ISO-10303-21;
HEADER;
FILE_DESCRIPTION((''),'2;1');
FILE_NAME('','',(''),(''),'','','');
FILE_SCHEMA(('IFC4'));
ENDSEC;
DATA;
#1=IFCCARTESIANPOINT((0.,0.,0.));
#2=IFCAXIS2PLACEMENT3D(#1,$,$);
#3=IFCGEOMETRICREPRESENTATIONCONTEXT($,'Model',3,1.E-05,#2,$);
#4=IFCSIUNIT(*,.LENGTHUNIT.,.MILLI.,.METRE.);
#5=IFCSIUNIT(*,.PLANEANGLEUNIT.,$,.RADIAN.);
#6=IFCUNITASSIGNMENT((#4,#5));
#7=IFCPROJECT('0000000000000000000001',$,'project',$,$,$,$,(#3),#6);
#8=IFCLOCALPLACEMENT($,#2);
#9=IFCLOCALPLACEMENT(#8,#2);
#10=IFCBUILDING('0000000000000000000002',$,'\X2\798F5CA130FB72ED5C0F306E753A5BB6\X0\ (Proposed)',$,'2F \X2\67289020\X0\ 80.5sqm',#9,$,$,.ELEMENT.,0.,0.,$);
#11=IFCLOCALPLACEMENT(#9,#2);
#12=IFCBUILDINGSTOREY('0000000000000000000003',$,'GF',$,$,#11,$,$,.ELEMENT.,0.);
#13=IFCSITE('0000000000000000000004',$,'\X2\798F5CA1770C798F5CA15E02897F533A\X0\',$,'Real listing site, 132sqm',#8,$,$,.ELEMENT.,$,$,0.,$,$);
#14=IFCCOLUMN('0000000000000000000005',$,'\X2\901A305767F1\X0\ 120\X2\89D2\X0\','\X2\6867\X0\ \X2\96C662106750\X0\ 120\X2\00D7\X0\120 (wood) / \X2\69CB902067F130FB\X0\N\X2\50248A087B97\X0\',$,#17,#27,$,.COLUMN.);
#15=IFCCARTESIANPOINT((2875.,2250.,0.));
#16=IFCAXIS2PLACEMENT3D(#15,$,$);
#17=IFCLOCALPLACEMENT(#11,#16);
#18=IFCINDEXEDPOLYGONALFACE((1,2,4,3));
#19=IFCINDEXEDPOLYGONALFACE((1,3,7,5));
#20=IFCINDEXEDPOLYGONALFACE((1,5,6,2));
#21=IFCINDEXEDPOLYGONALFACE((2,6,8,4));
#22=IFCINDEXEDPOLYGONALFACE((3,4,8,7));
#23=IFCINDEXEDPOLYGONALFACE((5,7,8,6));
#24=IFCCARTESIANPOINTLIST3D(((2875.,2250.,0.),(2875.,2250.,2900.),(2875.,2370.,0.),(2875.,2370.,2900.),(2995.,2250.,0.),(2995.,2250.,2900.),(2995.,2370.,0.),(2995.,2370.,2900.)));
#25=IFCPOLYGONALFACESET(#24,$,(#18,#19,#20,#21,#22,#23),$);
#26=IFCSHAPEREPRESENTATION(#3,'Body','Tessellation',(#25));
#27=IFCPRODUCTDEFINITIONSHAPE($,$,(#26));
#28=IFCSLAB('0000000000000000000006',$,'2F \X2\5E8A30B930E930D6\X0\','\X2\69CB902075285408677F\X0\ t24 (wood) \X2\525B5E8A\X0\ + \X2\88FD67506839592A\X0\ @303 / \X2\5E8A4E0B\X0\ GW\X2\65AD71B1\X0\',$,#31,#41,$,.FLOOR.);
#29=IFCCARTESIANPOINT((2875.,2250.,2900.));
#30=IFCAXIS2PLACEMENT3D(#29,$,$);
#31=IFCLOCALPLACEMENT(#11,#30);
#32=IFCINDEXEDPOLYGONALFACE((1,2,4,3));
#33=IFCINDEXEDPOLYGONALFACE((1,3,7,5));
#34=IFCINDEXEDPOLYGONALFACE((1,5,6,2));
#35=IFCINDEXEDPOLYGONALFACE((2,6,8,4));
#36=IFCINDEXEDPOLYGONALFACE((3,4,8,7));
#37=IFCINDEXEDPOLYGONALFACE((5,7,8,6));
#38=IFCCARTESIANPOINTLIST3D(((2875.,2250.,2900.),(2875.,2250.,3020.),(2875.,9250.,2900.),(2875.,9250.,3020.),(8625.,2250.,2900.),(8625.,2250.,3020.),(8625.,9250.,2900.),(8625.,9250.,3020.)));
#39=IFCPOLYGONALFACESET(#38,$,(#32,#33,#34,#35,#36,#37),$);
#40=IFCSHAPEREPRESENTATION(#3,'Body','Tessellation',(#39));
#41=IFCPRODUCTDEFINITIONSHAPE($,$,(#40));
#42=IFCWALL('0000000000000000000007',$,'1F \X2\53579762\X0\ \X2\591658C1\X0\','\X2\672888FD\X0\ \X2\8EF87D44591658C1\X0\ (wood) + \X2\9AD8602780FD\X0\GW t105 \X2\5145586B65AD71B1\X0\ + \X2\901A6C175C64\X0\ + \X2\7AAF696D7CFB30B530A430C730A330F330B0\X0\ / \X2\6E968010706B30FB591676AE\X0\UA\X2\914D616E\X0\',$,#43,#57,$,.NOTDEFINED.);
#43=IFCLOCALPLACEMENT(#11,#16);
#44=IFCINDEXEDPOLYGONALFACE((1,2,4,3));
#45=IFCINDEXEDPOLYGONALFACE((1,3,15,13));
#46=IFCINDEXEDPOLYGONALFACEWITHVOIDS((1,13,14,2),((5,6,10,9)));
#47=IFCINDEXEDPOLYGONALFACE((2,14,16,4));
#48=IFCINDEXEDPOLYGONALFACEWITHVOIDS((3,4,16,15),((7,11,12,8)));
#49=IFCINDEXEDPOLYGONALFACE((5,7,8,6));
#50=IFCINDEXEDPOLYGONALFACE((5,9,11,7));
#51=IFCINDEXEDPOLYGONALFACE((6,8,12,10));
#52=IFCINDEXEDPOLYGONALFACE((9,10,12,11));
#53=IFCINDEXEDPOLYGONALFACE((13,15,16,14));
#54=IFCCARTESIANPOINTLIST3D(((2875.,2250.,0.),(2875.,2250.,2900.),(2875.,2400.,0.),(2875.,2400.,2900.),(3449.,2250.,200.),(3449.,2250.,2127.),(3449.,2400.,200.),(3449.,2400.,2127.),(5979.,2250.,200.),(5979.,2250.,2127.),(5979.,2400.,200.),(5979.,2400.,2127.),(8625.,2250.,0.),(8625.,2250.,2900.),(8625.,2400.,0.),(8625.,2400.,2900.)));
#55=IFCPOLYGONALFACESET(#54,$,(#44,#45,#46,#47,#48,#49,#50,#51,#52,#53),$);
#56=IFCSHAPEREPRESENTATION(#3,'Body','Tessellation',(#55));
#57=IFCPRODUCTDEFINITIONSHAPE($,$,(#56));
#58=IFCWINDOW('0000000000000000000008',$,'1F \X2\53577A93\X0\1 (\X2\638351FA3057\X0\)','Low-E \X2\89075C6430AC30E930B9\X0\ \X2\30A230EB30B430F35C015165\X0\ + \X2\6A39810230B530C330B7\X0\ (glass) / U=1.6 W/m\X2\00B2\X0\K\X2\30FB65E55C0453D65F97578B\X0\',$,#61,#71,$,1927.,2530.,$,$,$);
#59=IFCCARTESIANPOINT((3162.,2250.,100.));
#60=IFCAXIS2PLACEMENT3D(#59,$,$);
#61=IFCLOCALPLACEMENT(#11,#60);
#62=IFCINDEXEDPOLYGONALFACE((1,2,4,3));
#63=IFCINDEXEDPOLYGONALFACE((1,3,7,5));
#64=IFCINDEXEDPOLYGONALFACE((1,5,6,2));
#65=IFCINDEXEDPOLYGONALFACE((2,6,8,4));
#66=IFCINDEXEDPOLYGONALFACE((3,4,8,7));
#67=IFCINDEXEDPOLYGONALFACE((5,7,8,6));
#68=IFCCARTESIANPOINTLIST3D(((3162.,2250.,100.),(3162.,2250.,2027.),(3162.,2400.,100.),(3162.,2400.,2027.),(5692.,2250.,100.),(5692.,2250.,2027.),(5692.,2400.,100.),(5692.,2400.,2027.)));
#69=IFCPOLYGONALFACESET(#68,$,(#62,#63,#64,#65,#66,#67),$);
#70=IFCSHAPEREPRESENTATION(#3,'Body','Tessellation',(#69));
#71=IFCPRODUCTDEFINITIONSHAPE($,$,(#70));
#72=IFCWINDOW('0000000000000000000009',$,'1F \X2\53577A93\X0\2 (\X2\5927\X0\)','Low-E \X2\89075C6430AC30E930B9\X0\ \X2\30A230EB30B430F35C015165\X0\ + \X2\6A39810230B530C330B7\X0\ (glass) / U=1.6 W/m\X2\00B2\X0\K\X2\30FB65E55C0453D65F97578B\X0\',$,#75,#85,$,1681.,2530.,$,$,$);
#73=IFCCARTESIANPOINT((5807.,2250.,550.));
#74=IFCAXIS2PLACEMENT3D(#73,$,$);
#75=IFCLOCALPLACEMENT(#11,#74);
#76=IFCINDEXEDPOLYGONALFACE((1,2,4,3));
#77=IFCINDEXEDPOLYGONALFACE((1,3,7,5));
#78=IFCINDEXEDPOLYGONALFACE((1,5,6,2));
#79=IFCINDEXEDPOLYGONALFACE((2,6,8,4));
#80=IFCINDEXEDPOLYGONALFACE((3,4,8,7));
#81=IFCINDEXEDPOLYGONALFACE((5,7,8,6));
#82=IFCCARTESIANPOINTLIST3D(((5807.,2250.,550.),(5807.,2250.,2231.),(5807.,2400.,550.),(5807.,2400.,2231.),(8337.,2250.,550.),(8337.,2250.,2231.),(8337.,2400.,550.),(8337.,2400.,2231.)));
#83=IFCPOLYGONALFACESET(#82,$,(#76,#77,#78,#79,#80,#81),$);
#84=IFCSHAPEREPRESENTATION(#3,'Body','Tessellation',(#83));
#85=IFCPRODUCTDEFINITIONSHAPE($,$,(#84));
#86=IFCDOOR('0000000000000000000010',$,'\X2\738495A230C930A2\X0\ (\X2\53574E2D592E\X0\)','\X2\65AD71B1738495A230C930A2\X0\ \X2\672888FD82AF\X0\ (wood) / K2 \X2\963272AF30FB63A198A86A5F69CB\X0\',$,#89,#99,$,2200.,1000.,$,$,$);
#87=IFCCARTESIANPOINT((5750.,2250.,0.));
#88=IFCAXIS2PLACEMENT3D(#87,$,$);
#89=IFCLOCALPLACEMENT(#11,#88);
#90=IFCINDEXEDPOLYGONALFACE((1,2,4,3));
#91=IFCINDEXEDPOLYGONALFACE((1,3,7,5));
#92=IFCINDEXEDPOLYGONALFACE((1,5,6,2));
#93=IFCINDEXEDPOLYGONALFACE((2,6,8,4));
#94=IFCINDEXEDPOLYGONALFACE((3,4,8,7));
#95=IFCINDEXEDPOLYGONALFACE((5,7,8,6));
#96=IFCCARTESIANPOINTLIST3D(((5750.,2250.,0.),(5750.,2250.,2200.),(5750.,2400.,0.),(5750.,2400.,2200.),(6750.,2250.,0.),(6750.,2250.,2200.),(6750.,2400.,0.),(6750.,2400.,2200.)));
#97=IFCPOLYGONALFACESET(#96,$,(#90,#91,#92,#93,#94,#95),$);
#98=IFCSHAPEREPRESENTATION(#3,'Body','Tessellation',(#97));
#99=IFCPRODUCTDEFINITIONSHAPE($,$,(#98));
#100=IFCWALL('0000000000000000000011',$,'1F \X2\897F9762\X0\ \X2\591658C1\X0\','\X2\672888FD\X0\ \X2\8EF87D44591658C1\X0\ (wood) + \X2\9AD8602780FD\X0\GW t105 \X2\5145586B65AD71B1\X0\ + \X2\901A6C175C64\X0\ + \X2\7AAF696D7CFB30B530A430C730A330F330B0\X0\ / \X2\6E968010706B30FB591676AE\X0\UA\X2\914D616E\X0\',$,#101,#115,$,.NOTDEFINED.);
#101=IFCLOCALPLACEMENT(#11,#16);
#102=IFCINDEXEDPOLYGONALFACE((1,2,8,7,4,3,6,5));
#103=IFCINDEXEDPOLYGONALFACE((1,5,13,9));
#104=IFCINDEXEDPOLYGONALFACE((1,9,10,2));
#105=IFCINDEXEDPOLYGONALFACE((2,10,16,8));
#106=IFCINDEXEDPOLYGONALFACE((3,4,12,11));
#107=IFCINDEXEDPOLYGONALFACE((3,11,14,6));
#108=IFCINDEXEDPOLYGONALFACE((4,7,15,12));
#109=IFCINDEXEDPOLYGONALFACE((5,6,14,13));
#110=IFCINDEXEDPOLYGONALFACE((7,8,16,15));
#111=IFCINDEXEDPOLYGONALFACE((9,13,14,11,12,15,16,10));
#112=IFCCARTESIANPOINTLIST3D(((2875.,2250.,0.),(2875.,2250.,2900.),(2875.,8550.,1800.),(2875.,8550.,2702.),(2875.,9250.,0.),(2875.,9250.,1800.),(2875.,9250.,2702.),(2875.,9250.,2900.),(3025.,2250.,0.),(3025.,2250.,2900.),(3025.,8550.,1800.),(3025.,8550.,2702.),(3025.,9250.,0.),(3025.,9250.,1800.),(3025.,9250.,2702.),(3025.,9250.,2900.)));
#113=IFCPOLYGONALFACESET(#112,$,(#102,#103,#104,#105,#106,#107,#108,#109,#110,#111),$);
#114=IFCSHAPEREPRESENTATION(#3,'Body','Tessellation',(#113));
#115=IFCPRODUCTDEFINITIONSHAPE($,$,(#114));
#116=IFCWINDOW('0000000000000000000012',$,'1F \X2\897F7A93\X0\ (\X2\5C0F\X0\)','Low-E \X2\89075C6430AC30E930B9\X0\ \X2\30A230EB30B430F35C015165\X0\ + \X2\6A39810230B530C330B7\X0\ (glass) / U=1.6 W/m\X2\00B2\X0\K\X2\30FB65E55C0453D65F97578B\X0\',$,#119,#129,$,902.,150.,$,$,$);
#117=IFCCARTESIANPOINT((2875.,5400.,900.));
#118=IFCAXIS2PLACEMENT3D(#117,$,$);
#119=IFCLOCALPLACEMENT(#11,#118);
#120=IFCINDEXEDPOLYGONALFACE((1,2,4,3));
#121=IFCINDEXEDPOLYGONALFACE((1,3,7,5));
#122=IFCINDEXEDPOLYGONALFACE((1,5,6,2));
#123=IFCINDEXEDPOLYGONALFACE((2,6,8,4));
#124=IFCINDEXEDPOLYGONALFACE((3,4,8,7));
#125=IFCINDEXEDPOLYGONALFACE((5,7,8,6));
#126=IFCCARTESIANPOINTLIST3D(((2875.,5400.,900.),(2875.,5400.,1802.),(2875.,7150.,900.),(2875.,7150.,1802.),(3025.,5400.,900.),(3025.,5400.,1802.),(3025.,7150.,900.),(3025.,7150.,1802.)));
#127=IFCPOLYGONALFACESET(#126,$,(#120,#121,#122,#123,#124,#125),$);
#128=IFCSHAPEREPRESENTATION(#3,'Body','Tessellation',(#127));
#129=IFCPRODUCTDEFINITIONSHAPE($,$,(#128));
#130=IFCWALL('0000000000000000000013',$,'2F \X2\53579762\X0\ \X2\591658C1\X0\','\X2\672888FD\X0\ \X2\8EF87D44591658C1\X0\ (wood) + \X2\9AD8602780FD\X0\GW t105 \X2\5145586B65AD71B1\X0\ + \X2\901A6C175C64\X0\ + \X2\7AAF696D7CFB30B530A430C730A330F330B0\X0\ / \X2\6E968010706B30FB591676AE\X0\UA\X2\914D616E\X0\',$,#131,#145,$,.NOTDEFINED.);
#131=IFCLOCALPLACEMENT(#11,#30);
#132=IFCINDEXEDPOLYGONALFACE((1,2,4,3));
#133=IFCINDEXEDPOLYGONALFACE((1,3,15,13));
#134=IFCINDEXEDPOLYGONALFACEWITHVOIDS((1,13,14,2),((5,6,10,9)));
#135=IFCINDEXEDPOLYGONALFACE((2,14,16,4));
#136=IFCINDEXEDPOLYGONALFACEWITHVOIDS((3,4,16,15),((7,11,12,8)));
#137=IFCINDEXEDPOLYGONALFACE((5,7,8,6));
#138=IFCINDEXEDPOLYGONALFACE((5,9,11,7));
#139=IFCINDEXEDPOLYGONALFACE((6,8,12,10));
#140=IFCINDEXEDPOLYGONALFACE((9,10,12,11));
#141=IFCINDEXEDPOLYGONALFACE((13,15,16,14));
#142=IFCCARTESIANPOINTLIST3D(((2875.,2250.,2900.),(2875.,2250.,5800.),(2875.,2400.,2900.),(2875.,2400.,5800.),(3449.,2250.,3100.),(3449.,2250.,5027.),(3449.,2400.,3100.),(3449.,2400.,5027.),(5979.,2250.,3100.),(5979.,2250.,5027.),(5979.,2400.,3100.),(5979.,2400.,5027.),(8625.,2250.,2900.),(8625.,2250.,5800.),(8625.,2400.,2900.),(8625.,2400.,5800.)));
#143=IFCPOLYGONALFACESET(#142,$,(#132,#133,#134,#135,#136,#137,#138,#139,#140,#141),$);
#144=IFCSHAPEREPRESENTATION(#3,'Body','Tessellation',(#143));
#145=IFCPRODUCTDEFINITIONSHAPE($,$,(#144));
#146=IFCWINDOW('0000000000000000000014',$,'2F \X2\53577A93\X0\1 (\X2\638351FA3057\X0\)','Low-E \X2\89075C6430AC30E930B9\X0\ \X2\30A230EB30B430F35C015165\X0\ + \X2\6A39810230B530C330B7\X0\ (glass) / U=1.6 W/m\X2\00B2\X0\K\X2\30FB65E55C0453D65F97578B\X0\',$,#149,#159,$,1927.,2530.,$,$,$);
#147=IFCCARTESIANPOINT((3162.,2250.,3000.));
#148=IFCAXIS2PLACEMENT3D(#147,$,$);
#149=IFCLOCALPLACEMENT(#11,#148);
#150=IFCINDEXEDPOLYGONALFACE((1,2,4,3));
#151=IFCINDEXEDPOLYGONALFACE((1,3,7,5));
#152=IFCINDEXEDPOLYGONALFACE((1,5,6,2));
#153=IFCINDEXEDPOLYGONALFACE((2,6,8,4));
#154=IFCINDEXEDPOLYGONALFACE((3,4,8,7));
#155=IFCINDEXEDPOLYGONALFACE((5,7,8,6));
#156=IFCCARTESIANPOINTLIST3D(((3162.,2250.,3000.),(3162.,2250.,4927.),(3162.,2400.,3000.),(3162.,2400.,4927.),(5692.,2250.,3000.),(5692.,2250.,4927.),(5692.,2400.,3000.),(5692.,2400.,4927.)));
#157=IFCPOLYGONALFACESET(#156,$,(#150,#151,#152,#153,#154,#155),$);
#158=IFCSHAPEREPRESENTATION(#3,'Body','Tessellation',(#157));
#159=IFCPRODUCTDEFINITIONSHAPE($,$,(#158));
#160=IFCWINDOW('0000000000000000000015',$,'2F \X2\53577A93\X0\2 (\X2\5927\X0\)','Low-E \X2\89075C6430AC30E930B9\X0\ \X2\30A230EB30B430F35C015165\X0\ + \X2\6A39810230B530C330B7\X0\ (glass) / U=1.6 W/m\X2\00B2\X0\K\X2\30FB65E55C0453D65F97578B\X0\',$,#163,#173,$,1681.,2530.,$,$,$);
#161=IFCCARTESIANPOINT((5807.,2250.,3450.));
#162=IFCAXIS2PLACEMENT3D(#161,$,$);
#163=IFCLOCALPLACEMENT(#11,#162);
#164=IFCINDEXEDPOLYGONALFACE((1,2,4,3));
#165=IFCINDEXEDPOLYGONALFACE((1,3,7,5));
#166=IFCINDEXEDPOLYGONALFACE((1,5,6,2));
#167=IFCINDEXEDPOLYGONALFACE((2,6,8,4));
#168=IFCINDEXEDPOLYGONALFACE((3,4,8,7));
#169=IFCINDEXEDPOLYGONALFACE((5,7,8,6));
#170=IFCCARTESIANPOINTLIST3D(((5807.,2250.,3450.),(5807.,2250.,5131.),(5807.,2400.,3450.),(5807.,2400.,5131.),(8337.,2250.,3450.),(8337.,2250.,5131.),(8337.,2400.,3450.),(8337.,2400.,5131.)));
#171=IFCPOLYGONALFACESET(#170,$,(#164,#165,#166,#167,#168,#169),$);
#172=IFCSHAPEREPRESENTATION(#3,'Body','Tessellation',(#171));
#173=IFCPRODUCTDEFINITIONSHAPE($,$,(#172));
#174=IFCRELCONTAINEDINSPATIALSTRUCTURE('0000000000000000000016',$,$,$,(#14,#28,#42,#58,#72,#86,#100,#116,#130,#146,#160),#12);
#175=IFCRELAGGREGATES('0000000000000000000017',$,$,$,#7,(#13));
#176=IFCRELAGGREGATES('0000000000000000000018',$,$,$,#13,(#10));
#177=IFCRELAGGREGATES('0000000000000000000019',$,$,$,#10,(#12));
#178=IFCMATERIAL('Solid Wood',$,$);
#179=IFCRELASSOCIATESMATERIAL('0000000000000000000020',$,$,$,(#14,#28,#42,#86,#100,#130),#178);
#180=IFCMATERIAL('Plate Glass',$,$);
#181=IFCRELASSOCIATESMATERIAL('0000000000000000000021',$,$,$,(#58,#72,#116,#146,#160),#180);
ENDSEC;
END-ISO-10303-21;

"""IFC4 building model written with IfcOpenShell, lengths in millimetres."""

from ifc_helpers import new_model, si_unit, frame, frame_2d, origin, place, context, project, spatial, rectangle, extrude, material, element, fill, save


model = new_model("IFC4")

# Units and contexts
model_context = context("Model", 3, precision=1e-05, world=origin())
ifc_project = project(units=[si_unit("LENGTHUNIT", "METRE", prefix="MILLI"), si_unit("PLANEANGLEUNIT", "RADIAN")], contexts=[model_context])

# Site, building, storey
site_placement = place(None, origin())
site = spatial("IfcSite", under=ifc_project, at=site_placement, Name="福岡県福岡市西区", ObjectType="Real listing site, 132sqm", CompositionType="ELEMENT", RefElevation=0.0)
building_placement = place(site_placement, origin())
building = spatial("IfcBuilding", under=site, at=building_placement, Name="福岡・狭小の町家 (Proposed)", ObjectType="2F 木造 80.5sqm", CompositionType="ELEMENT", ElevationOfRefHeight=0.0, ElevationOfTerrain=0.0)
storey_placement = place(building_placement, origin())
storey = spatial("IfcBuildingStorey", under=building, at=storey_placement, Name="GF", CompositionType="ELEMENT", Elevation=0.0)

# Column
ifc_material_1 = material(Name="Solid Wood")
column_placement = place(storey_placement, frame((2875.0, 2250.0, 0.0)))
element("IfcColumn", 1, at=column_placement, inside=storey, material=ifc_material_1, Name="通し柱 120角", Description="桧 集成材 120×120 (wood) / 構造柱・N値計算", PredefinedType="COLUMN", context=model_context, shape_type="SweptSolid", body=[
    extrude(rectangle(XDim=120.0, YDim=120.0, at=frame_2d((60.0, 60.0))), frame((2875.0, 2250.0, 0.0)), (0.0, 0.0, 1.0), 2900.0),
])

# Slab
slab_1_placement = place(storey_placement, frame((2875.0, 2250.0, 2900.0)))
element("IfcSlab", 2, at=slab_1_placement, inside=storey, material=ifc_material_1, Name="2F 床スラブ", Description="構造用合板 t24 (wood) 剛床 + 製材根太 @303 / 床下 GW断熱", PredefinedType="FLOOR", context=model_context, shape_type="SweptSolid", body=[
    extrude(rectangle(XDim=5750.0, YDim=7000.0, at=frame_2d((2875.0, 3500.0))), frame((2875.0, 2250.0, 2900.0)), (0.0, 0.0, 1.0), 120.0),
])

# Wall, openings, windows, door
wall_1_placement = place(storey_placement, frame((2875.0, 2250.0, 0.0)))
wall_1 = element("IfcWall", 3, at=wall_1_placement, inside=storey, material=ifc_material_1, Name="1F 南面 外壁", Description="木製 軸組外壁 (wood) + 高性能GW t105 充填断熱 + 通気層 + 窯業系サイディング / 準耐火・外皮UA配慮", PredefinedType="NOTDEFINED", context=model_context, shape_type="SweptSolid", body=[
    extrude(rectangle(XDim=5750.0, YDim=150.0, at=frame_2d((2875.0, 75.0))), frame((2875.0, 2250.0, 0.0)), (0.0, 0.0, 1.0), 2900.0),
])
opening_1_placement = place(storey_placement, frame((3162.0, 2250.0, 100.0)))
opening_1 = element("IfcOpeningElement", 4, at=opening_1_placement, cuts=wall_1, PredefinedType="NOTDEFINED", context=model_context, shape_type="SweptSolid", body=[
    extrude(rectangle(XDim=2530.0, YDim=150.0, at=frame_2d((1265.0, 75.0))), frame((3162.0, 2250.0, 100.0)), (0.0, 0.0, 1.0), 1927.0),
])
opening_2_placement = place(storey_placement, frame((5807.0, 2250.0, 550.0)))
opening_2 = element("IfcOpeningElement", 5, at=opening_2_placement, cuts=wall_1, PredefinedType="NOTDEFINED", context=model_context, shape_type="SweptSolid", body=[
    extrude(rectangle(XDim=2530.0, YDim=150.0, at=frame_2d((1265.0, 75.0))), frame((5807.0, 2250.0, 550.0)), (0.0, 0.0, 1.0), 1681.0),
])
opening_3_placement = place(storey_placement, frame((5750.0, 2250.0, 0.0)))
opening_3 = element("IfcOpeningElement", 6, at=opening_3_placement, cuts=wall_1, PredefinedType="NOTDEFINED", context=model_context, shape_type="SweptSolid", body=[
    extrude(rectangle(XDim=1000.0, YDim=150.0, at=frame_2d((500.0, 75.0))), frame((5750.0, 2250.0, 0.0)), (0.0, 0.0, 1.0), 2200.0),
])
ifc_material_2 = material(Name="Plate Glass")
window_1_placement = place(storey_placement, frame((3162.0, 2250.0, 100.0)))
window_1 = element("IfcWindow", 7, at=window_1_placement, inside=storey, material=ifc_material_2, Name="1F 南窓1 (掃出し)", Description="Low-E 複層ガラス アルゴン封入 + 樹脂サッシ (glass) / U=1.6 W/m²K・日射取得型", OverallHeight=1927.0, OverallWidth=2530.0, context=model_context, shape_type="SweptSolid", body=[
    extrude(rectangle(XDim=2530.0, YDim=150.0, at=frame_2d((1265.0, 75.0))), frame((3162.0, 2250.0, 100.0)), (0.0, 0.0, 1.0), 1927.0),
])
fill(opening_1, window_1)
window_2_placement = place(storey_placement, frame((5807.0, 2250.0, 550.0)))
window_2 = element("IfcWindow", 8, at=window_2_placement, inside=storey, material=ifc_material_2, Name="1F 南窓2 (大)", Description="Low-E 複層ガラス アルゴン封入 + 樹脂サッシ (glass) / U=1.6 W/m²K・日射取得型", OverallHeight=1681.0, OverallWidth=2530.0, context=model_context, shape_type="SweptSolid", body=[
    extrude(rectangle(XDim=2530.0, YDim=150.0, at=frame_2d((1265.0, 75.0))), frame((5807.0, 2250.0, 550.0)), (0.0, 0.0, 1.0), 1681.0),
])
fill(opening_2, window_2)
door_placement = place(storey_placement, frame((5750.0, 2250.0, 0.0)))
door = element("IfcDoor", 9, at=door_placement, inside=storey, material=ifc_material_1, Name="玄関ドア (南中央)", Description="断熱玄関ドア 木製芯 (wood) / K2 防犯・採風機構", OverallHeight=2200.0, OverallWidth=1000.0, context=model_context, shape_type="SweptSolid", body=[
    extrude(rectangle(XDim=1000.0, YDim=150.0, at=frame_2d((500.0, 75.0))), frame((5750.0, 2250.0, 0.0)), (0.0, 0.0, 1.0), 2200.0),
])
fill(opening_3, door)

# Wall, opening, window
wall_2_placement = place(storey_placement, frame((2875.0, 2250.0, 0.0)))
wall_2 = element("IfcWall", 10, at=wall_2_placement, inside=storey, material=ifc_material_1, Name="1F 西面 外壁", Description="木製 軸組外壁 (wood) + 高性能GW t105 充填断熱 + 通気層 + 窯業系サイディング / 準耐火・外皮UA配慮", PredefinedType="NOTDEFINED", context=model_context, shape_type="SweptSolid", body=[
    extrude(rectangle(XDim=150.0, YDim=7000.0, at=frame_2d((75.0, 3500.0))), frame((2875.0, 2250.0, 0.0)), (0.0, 0.0, 1.0), 2900.0),
])
opening_4_placement = place(storey_placement, frame((2875.0, 5400.0, 900.0)))
opening_4 = element("IfcOpeningElement", 11, at=opening_4_placement, cuts=wall_2, PredefinedType="NOTDEFINED", context=model_context, shape_type="SweptSolid", body=[
    extrude(rectangle(XDim=150.0, YDim=1750.0, at=frame_2d((75.0, 875.0))), frame((2875.0, 5400.0, 900.0)), (0.0, 0.0, 1.0), 902.0),
])
window_3_placement = place(storey_placement, frame((2875.0, 5400.0, 900.0)))
window_3 = element("IfcWindow", 12, at=window_3_placement, inside=storey, material=ifc_material_2, Name="1F 西窓 (小)", Description="Low-E 複層ガラス アルゴン封入 + 樹脂サッシ (glass) / U=1.6 W/m²K・日射取得型", OverallHeight=902.0, OverallWidth=150.0, context=model_context, shape_type="SweptSolid", body=[
    extrude(rectangle(XDim=150.0, YDim=1750.0, at=frame_2d((75.0, 875.0))), frame((2875.0, 5400.0, 900.0)), (0.0, 0.0, 1.0), 902.0),
])
fill(opening_4, window_3)

# Wall, openings, windows
wall_3_placement = place(storey_placement, frame((2875.0, 2250.0, 2900.0)))
wall_3 = element("IfcWall", 13, at=wall_3_placement, inside=storey, material=ifc_material_1, Name="2F 南面 外壁", Description="木製 軸組外壁 (wood) + 高性能GW t105 充填断熱 + 通気層 + 窯業系サイディング / 準耐火・外皮UA配慮", PredefinedType="NOTDEFINED", context=model_context, shape_type="SweptSolid", body=[
    extrude(rectangle(XDim=5750.0, YDim=150.0, at=frame_2d((2875.0, 75.0))), frame((2875.0, 2250.0, 2900.0)), (0.0, 0.0, 1.0), 2900.0),
])
opening_5_placement = place(storey_placement, frame((3162.0, 2250.0, 3000.0)))
opening_5 = element("IfcOpeningElement", 14, at=opening_5_placement, cuts=wall_3, PredefinedType="NOTDEFINED", context=model_context, shape_type="SweptSolid", body=[
    extrude(rectangle(XDim=2530.0, YDim=150.0, at=frame_2d((1265.0, 75.0))), frame((3162.0, 2250.0, 3000.0)), (0.0, 0.0, 1.0), 1927.0),
])
opening_6_placement = place(storey_placement, frame((5807.0, 2250.0, 3450.0)))
opening_6 = element("IfcOpeningElement", 15, at=opening_6_placement, cuts=wall_3, PredefinedType="NOTDEFINED", context=model_context, shape_type="SweptSolid", body=[
    extrude(rectangle(XDim=2530.0, YDim=150.0, at=frame_2d((1265.0, 75.0))), frame((5807.0, 2250.0, 3450.0)), (0.0, 0.0, 1.0), 1681.0),
])
window_4_placement = place(storey_placement, frame((3162.0, 2250.0, 3000.0)))
window_4 = element("IfcWindow", 16, at=window_4_placement, inside=storey, material=ifc_material_2, Name="2F 南窓1 (掃出し)", Description="Low-E 複層ガラス アルゴン封入 + 樹脂サッシ (glass) / U=1.6 W/m²K・日射取得型", OverallHeight=1927.0, OverallWidth=2530.0, context=model_context, shape_type="SweptSolid", body=[
    extrude(rectangle(XDim=2530.0, YDim=150.0, at=frame_2d((1265.0, 75.0))), frame((3162.0, 2250.0, 3000.0)), (0.0, 0.0, 1.0), 1927.0),
])
fill(opening_5, window_4)
window_5_placement = place(storey_placement, frame((5807.0, 2250.0, 3450.0)))
window_5 = element("IfcWindow", 17, at=window_5_placement, inside=storey, material=ifc_material_2, Name="2F 南窓2 (大)", Description="Low-E 複層ガラス アルゴン封入 + 樹脂サッシ (glass) / U=1.6 W/m²K・日射取得型", OverallHeight=1681.0, OverallWidth=2530.0, context=model_context, shape_type="SweptSolid", body=[
    extrude(rectangle(XDim=2530.0, YDim=150.0, at=frame_2d((1265.0, 75.0))), frame((5807.0, 2250.0, 3450.0)), (0.0, 0.0, 1.0), 1681.0),
])
fill(opening_6, window_5)

save(model, "model.ifc")
